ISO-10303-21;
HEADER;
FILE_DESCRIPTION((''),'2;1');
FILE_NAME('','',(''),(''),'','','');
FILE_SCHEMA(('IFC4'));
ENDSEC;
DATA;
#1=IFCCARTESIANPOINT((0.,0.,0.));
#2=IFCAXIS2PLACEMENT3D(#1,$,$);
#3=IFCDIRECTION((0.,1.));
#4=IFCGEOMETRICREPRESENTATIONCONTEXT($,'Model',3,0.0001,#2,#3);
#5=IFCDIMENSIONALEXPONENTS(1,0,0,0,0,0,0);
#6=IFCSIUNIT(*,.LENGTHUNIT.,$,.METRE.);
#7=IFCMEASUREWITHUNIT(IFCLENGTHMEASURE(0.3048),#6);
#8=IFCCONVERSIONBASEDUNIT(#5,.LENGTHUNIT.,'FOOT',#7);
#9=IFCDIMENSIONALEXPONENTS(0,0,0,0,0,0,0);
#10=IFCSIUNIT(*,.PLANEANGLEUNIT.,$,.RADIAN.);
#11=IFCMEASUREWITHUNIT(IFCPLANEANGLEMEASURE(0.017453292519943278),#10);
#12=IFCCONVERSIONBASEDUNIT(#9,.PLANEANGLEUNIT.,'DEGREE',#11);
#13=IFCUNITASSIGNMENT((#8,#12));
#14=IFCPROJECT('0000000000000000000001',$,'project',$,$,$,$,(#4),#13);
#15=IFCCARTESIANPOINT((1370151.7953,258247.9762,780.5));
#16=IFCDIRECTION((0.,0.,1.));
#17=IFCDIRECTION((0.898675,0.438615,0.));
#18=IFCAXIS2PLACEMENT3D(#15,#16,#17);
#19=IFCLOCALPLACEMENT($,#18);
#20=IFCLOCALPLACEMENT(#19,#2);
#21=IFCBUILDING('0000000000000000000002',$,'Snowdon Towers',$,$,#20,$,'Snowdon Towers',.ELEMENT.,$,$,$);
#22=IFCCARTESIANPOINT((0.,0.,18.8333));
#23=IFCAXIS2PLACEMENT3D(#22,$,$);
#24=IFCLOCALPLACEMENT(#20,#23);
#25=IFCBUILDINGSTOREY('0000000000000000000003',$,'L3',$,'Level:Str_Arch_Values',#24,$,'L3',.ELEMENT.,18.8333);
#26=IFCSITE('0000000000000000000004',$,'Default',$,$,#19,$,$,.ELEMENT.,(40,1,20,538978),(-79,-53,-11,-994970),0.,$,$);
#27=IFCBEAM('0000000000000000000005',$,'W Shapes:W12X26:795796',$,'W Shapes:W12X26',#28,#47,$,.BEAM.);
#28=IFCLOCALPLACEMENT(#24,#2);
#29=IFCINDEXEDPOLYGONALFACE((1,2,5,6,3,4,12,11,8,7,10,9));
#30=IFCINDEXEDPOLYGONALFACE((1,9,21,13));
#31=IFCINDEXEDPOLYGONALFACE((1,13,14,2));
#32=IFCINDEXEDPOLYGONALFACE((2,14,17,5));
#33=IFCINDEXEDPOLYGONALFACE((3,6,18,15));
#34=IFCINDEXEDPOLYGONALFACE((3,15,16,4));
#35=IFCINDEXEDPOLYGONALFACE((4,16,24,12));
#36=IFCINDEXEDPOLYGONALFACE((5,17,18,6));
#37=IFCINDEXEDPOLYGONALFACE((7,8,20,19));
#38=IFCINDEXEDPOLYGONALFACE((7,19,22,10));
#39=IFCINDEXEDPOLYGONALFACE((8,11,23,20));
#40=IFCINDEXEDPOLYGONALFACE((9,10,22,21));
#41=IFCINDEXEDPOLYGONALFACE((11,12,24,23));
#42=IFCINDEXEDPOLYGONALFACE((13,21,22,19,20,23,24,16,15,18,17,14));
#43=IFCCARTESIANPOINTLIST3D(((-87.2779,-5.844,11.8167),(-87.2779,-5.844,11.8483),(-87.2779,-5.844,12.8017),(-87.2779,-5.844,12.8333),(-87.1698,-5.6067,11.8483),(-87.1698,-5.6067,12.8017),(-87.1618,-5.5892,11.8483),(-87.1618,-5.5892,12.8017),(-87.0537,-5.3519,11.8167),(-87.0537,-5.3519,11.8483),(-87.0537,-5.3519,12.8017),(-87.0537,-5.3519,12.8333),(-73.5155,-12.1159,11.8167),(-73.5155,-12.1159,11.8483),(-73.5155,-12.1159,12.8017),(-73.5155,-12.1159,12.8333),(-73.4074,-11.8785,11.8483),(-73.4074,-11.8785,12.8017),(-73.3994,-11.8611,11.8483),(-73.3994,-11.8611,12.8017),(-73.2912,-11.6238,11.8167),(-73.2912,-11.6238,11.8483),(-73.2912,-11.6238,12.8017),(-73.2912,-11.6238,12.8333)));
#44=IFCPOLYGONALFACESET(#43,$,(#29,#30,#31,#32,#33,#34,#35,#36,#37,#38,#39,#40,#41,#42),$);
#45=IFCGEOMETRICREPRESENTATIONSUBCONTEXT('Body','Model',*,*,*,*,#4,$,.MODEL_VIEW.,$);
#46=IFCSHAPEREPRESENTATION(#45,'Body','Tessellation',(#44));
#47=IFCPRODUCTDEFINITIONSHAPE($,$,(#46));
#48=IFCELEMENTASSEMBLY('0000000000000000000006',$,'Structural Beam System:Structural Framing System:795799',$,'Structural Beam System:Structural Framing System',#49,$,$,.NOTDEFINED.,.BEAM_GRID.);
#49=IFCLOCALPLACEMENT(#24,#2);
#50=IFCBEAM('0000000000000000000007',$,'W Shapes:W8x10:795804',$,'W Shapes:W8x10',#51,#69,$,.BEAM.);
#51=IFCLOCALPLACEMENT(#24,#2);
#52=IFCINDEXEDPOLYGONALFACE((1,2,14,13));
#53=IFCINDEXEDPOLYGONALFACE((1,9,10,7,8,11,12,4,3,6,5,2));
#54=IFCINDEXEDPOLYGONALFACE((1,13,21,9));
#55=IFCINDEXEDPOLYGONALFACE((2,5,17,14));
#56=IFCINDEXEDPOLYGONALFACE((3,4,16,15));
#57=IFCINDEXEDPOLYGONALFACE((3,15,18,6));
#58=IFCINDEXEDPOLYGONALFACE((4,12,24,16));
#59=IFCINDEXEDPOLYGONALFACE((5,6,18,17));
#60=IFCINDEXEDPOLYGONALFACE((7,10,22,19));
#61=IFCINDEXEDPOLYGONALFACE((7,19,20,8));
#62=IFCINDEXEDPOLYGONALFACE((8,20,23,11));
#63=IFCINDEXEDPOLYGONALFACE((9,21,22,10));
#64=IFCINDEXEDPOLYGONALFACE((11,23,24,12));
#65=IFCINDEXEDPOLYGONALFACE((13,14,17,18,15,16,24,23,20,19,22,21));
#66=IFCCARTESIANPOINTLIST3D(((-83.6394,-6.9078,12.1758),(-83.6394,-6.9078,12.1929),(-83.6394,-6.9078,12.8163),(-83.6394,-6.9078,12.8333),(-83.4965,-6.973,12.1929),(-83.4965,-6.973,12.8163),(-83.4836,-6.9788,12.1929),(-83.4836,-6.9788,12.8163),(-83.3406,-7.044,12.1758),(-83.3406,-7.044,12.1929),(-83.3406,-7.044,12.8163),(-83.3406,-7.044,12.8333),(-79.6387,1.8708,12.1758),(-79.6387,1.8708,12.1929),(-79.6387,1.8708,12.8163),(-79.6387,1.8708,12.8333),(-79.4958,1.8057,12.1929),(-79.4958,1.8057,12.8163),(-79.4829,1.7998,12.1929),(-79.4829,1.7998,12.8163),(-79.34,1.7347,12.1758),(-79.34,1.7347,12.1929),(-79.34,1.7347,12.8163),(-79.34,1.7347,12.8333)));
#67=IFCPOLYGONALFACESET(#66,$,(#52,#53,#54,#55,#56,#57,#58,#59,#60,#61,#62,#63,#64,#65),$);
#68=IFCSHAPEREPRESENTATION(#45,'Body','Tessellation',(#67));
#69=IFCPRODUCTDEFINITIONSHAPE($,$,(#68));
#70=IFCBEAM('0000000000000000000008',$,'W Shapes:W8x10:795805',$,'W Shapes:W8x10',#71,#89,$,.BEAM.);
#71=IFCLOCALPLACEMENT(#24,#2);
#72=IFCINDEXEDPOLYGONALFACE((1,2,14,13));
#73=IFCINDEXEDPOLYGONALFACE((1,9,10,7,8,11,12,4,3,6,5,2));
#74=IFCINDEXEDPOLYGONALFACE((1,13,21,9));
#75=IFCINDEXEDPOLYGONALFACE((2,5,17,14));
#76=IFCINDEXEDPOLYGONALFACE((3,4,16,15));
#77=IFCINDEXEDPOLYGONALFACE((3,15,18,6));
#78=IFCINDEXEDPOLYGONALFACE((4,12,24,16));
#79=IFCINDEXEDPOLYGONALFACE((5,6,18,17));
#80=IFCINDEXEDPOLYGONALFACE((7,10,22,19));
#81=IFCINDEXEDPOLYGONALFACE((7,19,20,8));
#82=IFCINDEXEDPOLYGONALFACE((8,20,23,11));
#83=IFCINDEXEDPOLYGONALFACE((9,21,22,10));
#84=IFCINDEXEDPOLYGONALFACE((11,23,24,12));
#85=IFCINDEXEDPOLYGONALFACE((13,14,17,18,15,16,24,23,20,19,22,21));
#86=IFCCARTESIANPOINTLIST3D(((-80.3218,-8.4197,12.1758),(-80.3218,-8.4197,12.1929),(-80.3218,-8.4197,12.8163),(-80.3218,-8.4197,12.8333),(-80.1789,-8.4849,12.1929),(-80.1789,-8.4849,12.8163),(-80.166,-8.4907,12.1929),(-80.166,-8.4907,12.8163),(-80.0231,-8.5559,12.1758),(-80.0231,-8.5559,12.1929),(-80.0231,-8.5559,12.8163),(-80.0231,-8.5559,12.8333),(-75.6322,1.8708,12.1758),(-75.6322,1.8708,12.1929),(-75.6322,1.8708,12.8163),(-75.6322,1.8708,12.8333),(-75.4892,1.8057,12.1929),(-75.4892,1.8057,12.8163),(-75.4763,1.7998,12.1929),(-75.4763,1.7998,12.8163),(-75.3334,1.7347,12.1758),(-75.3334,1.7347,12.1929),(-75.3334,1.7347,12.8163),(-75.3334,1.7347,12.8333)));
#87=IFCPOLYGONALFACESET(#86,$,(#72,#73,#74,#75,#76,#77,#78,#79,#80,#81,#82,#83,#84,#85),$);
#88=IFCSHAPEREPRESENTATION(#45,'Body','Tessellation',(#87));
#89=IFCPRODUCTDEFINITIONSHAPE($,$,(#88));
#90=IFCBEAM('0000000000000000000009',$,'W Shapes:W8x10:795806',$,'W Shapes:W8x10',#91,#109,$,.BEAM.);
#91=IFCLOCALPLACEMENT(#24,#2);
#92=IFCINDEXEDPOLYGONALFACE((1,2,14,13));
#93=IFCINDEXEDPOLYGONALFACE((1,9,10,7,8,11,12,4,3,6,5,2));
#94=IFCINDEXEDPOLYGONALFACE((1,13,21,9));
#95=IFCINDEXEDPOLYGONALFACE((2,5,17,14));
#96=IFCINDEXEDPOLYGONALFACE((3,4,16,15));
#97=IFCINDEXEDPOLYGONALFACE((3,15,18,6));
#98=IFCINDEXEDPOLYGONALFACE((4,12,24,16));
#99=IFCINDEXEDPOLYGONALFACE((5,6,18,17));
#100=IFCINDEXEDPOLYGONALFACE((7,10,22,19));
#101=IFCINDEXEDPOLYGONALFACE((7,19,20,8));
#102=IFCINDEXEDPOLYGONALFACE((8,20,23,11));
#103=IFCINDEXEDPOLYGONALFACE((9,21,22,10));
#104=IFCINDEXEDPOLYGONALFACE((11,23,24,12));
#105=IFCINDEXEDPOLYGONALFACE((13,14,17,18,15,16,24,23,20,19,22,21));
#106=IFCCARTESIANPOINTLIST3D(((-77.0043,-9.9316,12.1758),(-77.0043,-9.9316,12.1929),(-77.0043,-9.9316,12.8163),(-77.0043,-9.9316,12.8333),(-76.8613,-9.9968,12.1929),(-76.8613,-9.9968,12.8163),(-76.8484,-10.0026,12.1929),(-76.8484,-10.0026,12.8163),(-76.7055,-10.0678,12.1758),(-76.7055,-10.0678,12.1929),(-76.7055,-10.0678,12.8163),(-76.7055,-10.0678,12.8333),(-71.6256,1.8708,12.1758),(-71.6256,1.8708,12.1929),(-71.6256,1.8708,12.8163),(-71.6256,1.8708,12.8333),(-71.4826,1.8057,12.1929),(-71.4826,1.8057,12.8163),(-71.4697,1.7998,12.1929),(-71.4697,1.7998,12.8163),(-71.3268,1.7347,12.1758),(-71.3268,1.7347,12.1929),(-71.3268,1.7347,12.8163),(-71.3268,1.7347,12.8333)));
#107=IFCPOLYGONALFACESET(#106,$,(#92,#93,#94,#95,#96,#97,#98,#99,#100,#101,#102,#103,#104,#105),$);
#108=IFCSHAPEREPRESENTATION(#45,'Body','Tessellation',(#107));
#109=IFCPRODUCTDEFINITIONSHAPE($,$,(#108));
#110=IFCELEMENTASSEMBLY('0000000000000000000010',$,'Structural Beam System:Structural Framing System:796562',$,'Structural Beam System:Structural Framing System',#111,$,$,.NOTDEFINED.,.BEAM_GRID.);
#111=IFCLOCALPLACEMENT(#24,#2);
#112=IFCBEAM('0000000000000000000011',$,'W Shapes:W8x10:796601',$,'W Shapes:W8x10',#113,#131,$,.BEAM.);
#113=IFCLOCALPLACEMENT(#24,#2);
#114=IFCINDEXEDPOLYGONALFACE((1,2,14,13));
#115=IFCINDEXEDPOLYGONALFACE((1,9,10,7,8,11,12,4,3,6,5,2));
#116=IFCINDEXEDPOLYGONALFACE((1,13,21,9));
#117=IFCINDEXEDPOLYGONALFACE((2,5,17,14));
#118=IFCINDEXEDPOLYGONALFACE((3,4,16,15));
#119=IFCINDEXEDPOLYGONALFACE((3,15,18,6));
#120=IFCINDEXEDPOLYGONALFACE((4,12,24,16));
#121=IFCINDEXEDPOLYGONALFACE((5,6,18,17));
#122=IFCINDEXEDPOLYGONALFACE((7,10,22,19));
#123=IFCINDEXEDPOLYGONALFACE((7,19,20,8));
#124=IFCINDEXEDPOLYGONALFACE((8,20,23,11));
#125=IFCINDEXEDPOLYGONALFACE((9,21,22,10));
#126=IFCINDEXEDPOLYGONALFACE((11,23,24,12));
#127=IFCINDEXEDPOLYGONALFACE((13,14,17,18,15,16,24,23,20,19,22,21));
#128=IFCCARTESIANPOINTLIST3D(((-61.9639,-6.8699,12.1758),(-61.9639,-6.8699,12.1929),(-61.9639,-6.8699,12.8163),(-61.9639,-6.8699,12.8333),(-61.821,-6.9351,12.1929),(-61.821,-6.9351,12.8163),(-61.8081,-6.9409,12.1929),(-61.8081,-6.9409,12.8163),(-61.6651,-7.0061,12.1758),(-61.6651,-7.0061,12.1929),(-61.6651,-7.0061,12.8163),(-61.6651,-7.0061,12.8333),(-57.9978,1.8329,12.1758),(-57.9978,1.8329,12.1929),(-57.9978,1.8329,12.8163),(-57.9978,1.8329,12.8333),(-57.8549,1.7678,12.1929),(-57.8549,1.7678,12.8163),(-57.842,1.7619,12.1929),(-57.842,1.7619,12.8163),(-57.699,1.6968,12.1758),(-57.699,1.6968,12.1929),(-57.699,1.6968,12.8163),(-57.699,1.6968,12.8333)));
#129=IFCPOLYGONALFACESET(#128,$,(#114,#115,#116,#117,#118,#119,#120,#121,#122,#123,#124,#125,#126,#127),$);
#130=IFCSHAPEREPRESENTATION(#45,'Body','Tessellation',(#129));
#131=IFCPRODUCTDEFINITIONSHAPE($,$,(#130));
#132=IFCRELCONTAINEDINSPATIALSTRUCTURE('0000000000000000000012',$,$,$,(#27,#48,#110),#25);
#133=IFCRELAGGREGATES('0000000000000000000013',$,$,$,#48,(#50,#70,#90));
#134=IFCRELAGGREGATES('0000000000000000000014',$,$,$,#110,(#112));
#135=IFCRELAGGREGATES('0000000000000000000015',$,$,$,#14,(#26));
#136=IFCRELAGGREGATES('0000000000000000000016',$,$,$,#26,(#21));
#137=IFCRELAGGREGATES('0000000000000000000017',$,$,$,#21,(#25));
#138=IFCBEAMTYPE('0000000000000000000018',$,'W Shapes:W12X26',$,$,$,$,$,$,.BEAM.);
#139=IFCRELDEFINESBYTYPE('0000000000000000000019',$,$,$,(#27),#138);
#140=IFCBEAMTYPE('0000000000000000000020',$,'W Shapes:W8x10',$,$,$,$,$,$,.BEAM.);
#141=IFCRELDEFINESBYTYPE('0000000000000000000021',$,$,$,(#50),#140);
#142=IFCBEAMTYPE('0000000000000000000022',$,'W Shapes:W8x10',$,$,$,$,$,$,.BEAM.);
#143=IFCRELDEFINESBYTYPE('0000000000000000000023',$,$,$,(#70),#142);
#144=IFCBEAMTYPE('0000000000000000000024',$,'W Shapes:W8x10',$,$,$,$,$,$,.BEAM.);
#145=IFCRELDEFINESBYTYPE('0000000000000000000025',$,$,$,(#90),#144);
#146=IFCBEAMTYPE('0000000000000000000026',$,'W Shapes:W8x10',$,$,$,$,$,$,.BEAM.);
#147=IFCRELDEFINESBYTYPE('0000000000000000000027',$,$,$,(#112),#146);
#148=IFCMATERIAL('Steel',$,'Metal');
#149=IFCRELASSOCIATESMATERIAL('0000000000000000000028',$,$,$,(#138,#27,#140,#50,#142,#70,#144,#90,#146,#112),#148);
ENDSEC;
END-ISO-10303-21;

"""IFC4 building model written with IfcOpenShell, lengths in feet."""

from ifc_helpers import new_model, entity, si_unit, converted_unit, direction, frame, origin, place, context, subcontext, project, spatial, indexed_curve, outline, extrude, source, transform, mapped, material, type_object, type_shapes, element, aggregate, save


model = new_model("IFC4")

# Units and contexts
model_context = context("Model", 3, precision=0.0001, world=origin(), true_north=direction((0.0, 1.0)))
body_context = subcontext(model_context, "Body", "Model", "MODEL_VIEW")
ifc_project = project(units=[converted_unit("LENGTHUNIT", "FOOT", entity("IfcLengthMeasure", 0.3048), si_unit("LENGTHUNIT", "METRE"), dimensions=[1, 0, 0, 0, 0, 0, 0]), converted_unit("PLANEANGLEUNIT", "DEGREE", entity("IfcPlaneAngleMeasure", 0.017453292519943278), si_unit("PLANEANGLEUNIT", "RADIAN"), dimensions=[0, 0, 0, 0, 0, 0, 0])], contexts=[model_context])

# Site, building, storey
site_placement = place(None, frame((1370151.7953, 258247.9762, 780.5), z_axis=(0.0, 0.0, 1.0), x_axis=(0.898675, 0.438615, 0.0)))
site = spatial("IfcSite", under=ifc_project, at=site_placement, Name="Default", CompositionType="ELEMENT", RefLatitude=(40, 1, 20, 538978), RefLongitude=(-79, -53, -11, -994970), RefElevation=0.0)
building_placement = place(site_placement, origin())
building = spatial("IfcBuilding", under=site, at=building_placement, Name="Snowdon Towers", LongName="Snowdon Towers", CompositionType="ELEMENT")
storey_placement = place(building_placement, frame((0.0, 0.0, 18.8333)))
storey = spatial("IfcBuildingStorey", under=building, at=storey_placement, Name="L3", ObjectType="Level:Str_Arch_Values", LongName="L3", CompositionType="ELEMENT", Elevation=18.8333)

# Shared definitions
ifc_material = material(Name="Steel", Category="Metal")

# Beam
beam_type_1 = type_object("IfcBeamType", Name="W Shapes:W12X26", PredefinedType="BEAM", material=ifc_material)
shared_shape_1 = source(origin(), body_context, "Body", "SweptSolid", [
    extrude(outline(indexed_curve([(-0.2704, -0.4767), (-0.2704, -0.5083), (0.2704, -0.5083), (0.2704, -0.4767), (0.0096, -0.4767), (0.0096, 0.4767), (0.2704, 0.4767), (0.2704, 0.5083), (-0.2704, 0.5083), (-0.2704, 0.4767), (-0.0096, 0.4767), (-0.0096, -0.4767), (-0.2704, -0.4767)], self_intersect=False)), frame((-7.5621, 0.0, 0.0), z_axis=(-1.0, 0.0, 0.0), x_axis=(0.0, -1.0, 0.0)), (0.0, 0.0, -1.0), 15.1242),
])
type_shapes(beam_type_1, [shared_shape_1])
beam_1_placement = place(storey_placement, frame((-80.2846, -8.7339, 12.325), z_axis=(0.0, 0.0, 1.0), x_axis=(0.909961, -0.414693, 0.0)))
element("IfcBeam", 1, at=beam_1_placement, inside=storey, type_object=beam_type_1, material=ifc_material, Name="W Shapes:W12X26:795796", ObjectType="W Shapes:W12X26", PredefinedType="BEAM", context=body_context, shape_type="MappedRepresentation", body=[
    mapped(shared_shape_1, transform((0.0, 0.0, 0.0), scale=1.0)),
])

# Element assembly, beams
assembly_1_placement = place(storey_placement, origin())
assembly_1 = element("IfcElementAssembly", 2, at=assembly_1_placement, inside=storey, Name="Structural Beam System:Structural Framing System:795799", ObjectType="Structural Beam System:Structural Framing System", AssemblyPlace="NOTDEFINED", PredefinedType="BEAM_GRID")
beam_type_2 = type_object("IfcBeamType", Name="W Shapes:W8x10", PredefinedType="BEAM", material=ifc_material)
shared_shape_2 = source(origin(), body_context, "Body", "SweptSolid", [
    extrude(outline(indexed_curve([(-0.1642, -0.3117), (-0.1642, -0.3288), (0.1642, -0.3288), (0.1642, -0.3117), (0.0071, -0.3117), (0.0071, 0.3117), (0.1642, 0.3117), (0.1642, 0.3287), (-0.1642, 0.3287), (-0.1642, 0.3117), (-0.0071, 0.3117), (-0.0071, -0.3117), (-0.1642, -0.3117)], self_intersect=False)), frame((-5.0716, 0.0, 0.0), z_axis=(-1.0, 0.0, 0.0), x_axis=(0.0, -1.0, 0.0)), (0.0, 0.0, -1.0), 9.6473),
])
type_shapes(beam_type_2, [shared_shape_2])
beam_2_placement = place(assembly_1_placement, frame((-81.3869, -2.361, 12.5046), z_axis=(0.0, 0.0, 1.0), x_axis=(0.414693, 0.909961, 0.0)))
beam_2 = element("IfcBeam", 3, at=beam_2_placement, type_object=beam_type_2, material=ifc_material, Name="W Shapes:W8x10:795804", ObjectType="W Shapes:W8x10", PredefinedType="BEAM", context=body_context, shape_type="MappedRepresentation", body=[
    mapped(shared_shape_2, transform((0.0, 0.0, 0.0), scale=1.0)),
])
beam_type_3 = type_object("IfcBeamType", Name="W Shapes:W8x10", PredefinedType="BEAM", material=ifc_material)
shared_shape_3 = source(origin(), body_context, "Body", "SweptSolid", [
    extrude(outline(indexed_curve([(-0.1642, -0.3117), (-0.1642, -0.3288), (0.1642, -0.3288), (0.1642, -0.3117), (0.0071, -0.3117), (0.0071, 0.3117), (0.1642, 0.3117), (0.1642, 0.3287), (-0.1642, 0.3287), (-0.1642, 0.3117), (-0.0071, 0.3117), (-0.0071, -0.3117), (-0.1642, -0.3117)], self_intersect=False)), frame((-5.9023, 0.0, 0.0), z_axis=(-1.0, 0.0, 0.0), x_axis=(0.0, -1.0, 0.0)), (0.0, 0.0, -1.0), 11.3088),
])
type_shapes(beam_type_3, [shared_shape_3])
beam_3_placement = place(assembly_1_placement, frame((-77.7248, -3.1169, 12.5046), z_axis=(0.0, 0.0, 1.0), x_axis=(0.414693, 0.909961, 0.0)))
beam_3 = element("IfcBeam", 4, at=beam_3_placement, type_object=beam_type_3, material=ifc_material, Name="W Shapes:W8x10:795805", ObjectType="W Shapes:W8x10", PredefinedType="BEAM", context=body_context, shape_type="MappedRepresentation", body=[
    mapped(shared_shape_3, transform((0.0, 0.0, 0.0), scale=1.0)),
])
beam_type_4 = type_object("IfcBeamType", Name="W Shapes:W8x10", PredefinedType="BEAM", material=ifc_material)
shared_shape_4 = source(origin(), body_context, "Body", "SweptSolid", [
    extrude(outline(indexed_curve([(-0.1642, -0.3117), (-0.1642, -0.3288), (0.1642, -0.3288), (0.1642, -0.3117), (0.0071, -0.3117), (0.0071, 0.3117), (0.1642, 0.3117), (0.1642, 0.3287), (-0.1642, 0.3287), (-0.1642, 0.3117), (-0.0071, 0.3117), (-0.0071, -0.3117), (-0.1642, -0.3117)], self_intersect=False)), frame((-6.7331, 0.0, 0.0), z_axis=(-1.0, 0.0, 0.0), x_axis=(0.0, -1.0, 0.0)), (0.0, 0.0, -1.0), 12.9703),
])
type_shapes(beam_type_4, [shared_shape_4])
beam_4_placement = place(assembly_1_placement, frame((-74.0627, -3.8729, 12.5046), z_axis=(0.0, 0.0, 1.0), x_axis=(0.414693, 0.909961, 0.0)))
beam_4 = element("IfcBeam", 5, at=beam_4_placement, type_object=beam_type_4, material=ifc_material, Name="W Shapes:W8x10:795806", ObjectType="W Shapes:W8x10", PredefinedType="BEAM", context=body_context, shape_type="MappedRepresentation", body=[
    mapped(shared_shape_4, transform((0.0, 0.0, 0.0), scale=1.0)),
])
aggregate(assembly_1, [beam_2, beam_3, beam_4])

# Element assembly, beam
assembly_2_placement = place(storey_placement, origin())
assembly_2 = element("IfcElementAssembly", 6, at=assembly_2_placement, inside=storey, Name="Structural Beam System:Structural Framing System:796562", ObjectType="Structural Beam System:Structural Framing System", AssemblyPlace="NOTDEFINED", PredefinedType="BEAM_GRID")
beam_type_5 = type_object("IfcBeamType", Name="W Shapes:W8x10", PredefinedType="BEAM", material=ifc_material)
shared_shape_5 = source(origin(), body_context, "Body", "SweptSolid", [
    extrude(outline(indexed_curve([(-0.1642, -0.3117), (-0.1642, -0.3288), (0.1642, -0.3288), (0.1642, -0.3117), (0.0071, -0.3117), (0.0071, 0.3117), (0.1642, 0.3117), (0.1642, 0.3287), (-0.1642, 0.3287), (-0.1642, 0.3117), (-0.0071, 0.3117), (-0.0071, -0.3117), (-0.1642, -0.3117)], self_intersect=False)), frame((-5.0299, 0.0, 0.0), z_axis=(-1.0, 0.0, 0.0), x_axis=(0.0, -1.0, 0.0)), (0.0, 0.0, -1.0), 9.564),
])
type_shapes(beam_type_5, [shared_shape_5])
beam_5_placement = place(assembly_2_placement, frame((-59.7287, -2.361, 12.5046), z_axis=(0.0, 0.0, 1.0), x_axis=(0.414693, 0.909961, 0.0)))
beam_5 = element("IfcBeam", 7, at=beam_5_placement, type_object=beam_type_5, material=ifc_material, Name="W Shapes:W8x10:796601", ObjectType="W Shapes:W8x10", PredefinedType="BEAM", context=body_context, shape_type="MappedRepresentation", body=[
    mapped(shared_shape_5, transform((0.0, 0.0, 0.0), scale=1.0)),
])
aggregate(assembly_2, [beam_5])

save(model, "model.ifc")
